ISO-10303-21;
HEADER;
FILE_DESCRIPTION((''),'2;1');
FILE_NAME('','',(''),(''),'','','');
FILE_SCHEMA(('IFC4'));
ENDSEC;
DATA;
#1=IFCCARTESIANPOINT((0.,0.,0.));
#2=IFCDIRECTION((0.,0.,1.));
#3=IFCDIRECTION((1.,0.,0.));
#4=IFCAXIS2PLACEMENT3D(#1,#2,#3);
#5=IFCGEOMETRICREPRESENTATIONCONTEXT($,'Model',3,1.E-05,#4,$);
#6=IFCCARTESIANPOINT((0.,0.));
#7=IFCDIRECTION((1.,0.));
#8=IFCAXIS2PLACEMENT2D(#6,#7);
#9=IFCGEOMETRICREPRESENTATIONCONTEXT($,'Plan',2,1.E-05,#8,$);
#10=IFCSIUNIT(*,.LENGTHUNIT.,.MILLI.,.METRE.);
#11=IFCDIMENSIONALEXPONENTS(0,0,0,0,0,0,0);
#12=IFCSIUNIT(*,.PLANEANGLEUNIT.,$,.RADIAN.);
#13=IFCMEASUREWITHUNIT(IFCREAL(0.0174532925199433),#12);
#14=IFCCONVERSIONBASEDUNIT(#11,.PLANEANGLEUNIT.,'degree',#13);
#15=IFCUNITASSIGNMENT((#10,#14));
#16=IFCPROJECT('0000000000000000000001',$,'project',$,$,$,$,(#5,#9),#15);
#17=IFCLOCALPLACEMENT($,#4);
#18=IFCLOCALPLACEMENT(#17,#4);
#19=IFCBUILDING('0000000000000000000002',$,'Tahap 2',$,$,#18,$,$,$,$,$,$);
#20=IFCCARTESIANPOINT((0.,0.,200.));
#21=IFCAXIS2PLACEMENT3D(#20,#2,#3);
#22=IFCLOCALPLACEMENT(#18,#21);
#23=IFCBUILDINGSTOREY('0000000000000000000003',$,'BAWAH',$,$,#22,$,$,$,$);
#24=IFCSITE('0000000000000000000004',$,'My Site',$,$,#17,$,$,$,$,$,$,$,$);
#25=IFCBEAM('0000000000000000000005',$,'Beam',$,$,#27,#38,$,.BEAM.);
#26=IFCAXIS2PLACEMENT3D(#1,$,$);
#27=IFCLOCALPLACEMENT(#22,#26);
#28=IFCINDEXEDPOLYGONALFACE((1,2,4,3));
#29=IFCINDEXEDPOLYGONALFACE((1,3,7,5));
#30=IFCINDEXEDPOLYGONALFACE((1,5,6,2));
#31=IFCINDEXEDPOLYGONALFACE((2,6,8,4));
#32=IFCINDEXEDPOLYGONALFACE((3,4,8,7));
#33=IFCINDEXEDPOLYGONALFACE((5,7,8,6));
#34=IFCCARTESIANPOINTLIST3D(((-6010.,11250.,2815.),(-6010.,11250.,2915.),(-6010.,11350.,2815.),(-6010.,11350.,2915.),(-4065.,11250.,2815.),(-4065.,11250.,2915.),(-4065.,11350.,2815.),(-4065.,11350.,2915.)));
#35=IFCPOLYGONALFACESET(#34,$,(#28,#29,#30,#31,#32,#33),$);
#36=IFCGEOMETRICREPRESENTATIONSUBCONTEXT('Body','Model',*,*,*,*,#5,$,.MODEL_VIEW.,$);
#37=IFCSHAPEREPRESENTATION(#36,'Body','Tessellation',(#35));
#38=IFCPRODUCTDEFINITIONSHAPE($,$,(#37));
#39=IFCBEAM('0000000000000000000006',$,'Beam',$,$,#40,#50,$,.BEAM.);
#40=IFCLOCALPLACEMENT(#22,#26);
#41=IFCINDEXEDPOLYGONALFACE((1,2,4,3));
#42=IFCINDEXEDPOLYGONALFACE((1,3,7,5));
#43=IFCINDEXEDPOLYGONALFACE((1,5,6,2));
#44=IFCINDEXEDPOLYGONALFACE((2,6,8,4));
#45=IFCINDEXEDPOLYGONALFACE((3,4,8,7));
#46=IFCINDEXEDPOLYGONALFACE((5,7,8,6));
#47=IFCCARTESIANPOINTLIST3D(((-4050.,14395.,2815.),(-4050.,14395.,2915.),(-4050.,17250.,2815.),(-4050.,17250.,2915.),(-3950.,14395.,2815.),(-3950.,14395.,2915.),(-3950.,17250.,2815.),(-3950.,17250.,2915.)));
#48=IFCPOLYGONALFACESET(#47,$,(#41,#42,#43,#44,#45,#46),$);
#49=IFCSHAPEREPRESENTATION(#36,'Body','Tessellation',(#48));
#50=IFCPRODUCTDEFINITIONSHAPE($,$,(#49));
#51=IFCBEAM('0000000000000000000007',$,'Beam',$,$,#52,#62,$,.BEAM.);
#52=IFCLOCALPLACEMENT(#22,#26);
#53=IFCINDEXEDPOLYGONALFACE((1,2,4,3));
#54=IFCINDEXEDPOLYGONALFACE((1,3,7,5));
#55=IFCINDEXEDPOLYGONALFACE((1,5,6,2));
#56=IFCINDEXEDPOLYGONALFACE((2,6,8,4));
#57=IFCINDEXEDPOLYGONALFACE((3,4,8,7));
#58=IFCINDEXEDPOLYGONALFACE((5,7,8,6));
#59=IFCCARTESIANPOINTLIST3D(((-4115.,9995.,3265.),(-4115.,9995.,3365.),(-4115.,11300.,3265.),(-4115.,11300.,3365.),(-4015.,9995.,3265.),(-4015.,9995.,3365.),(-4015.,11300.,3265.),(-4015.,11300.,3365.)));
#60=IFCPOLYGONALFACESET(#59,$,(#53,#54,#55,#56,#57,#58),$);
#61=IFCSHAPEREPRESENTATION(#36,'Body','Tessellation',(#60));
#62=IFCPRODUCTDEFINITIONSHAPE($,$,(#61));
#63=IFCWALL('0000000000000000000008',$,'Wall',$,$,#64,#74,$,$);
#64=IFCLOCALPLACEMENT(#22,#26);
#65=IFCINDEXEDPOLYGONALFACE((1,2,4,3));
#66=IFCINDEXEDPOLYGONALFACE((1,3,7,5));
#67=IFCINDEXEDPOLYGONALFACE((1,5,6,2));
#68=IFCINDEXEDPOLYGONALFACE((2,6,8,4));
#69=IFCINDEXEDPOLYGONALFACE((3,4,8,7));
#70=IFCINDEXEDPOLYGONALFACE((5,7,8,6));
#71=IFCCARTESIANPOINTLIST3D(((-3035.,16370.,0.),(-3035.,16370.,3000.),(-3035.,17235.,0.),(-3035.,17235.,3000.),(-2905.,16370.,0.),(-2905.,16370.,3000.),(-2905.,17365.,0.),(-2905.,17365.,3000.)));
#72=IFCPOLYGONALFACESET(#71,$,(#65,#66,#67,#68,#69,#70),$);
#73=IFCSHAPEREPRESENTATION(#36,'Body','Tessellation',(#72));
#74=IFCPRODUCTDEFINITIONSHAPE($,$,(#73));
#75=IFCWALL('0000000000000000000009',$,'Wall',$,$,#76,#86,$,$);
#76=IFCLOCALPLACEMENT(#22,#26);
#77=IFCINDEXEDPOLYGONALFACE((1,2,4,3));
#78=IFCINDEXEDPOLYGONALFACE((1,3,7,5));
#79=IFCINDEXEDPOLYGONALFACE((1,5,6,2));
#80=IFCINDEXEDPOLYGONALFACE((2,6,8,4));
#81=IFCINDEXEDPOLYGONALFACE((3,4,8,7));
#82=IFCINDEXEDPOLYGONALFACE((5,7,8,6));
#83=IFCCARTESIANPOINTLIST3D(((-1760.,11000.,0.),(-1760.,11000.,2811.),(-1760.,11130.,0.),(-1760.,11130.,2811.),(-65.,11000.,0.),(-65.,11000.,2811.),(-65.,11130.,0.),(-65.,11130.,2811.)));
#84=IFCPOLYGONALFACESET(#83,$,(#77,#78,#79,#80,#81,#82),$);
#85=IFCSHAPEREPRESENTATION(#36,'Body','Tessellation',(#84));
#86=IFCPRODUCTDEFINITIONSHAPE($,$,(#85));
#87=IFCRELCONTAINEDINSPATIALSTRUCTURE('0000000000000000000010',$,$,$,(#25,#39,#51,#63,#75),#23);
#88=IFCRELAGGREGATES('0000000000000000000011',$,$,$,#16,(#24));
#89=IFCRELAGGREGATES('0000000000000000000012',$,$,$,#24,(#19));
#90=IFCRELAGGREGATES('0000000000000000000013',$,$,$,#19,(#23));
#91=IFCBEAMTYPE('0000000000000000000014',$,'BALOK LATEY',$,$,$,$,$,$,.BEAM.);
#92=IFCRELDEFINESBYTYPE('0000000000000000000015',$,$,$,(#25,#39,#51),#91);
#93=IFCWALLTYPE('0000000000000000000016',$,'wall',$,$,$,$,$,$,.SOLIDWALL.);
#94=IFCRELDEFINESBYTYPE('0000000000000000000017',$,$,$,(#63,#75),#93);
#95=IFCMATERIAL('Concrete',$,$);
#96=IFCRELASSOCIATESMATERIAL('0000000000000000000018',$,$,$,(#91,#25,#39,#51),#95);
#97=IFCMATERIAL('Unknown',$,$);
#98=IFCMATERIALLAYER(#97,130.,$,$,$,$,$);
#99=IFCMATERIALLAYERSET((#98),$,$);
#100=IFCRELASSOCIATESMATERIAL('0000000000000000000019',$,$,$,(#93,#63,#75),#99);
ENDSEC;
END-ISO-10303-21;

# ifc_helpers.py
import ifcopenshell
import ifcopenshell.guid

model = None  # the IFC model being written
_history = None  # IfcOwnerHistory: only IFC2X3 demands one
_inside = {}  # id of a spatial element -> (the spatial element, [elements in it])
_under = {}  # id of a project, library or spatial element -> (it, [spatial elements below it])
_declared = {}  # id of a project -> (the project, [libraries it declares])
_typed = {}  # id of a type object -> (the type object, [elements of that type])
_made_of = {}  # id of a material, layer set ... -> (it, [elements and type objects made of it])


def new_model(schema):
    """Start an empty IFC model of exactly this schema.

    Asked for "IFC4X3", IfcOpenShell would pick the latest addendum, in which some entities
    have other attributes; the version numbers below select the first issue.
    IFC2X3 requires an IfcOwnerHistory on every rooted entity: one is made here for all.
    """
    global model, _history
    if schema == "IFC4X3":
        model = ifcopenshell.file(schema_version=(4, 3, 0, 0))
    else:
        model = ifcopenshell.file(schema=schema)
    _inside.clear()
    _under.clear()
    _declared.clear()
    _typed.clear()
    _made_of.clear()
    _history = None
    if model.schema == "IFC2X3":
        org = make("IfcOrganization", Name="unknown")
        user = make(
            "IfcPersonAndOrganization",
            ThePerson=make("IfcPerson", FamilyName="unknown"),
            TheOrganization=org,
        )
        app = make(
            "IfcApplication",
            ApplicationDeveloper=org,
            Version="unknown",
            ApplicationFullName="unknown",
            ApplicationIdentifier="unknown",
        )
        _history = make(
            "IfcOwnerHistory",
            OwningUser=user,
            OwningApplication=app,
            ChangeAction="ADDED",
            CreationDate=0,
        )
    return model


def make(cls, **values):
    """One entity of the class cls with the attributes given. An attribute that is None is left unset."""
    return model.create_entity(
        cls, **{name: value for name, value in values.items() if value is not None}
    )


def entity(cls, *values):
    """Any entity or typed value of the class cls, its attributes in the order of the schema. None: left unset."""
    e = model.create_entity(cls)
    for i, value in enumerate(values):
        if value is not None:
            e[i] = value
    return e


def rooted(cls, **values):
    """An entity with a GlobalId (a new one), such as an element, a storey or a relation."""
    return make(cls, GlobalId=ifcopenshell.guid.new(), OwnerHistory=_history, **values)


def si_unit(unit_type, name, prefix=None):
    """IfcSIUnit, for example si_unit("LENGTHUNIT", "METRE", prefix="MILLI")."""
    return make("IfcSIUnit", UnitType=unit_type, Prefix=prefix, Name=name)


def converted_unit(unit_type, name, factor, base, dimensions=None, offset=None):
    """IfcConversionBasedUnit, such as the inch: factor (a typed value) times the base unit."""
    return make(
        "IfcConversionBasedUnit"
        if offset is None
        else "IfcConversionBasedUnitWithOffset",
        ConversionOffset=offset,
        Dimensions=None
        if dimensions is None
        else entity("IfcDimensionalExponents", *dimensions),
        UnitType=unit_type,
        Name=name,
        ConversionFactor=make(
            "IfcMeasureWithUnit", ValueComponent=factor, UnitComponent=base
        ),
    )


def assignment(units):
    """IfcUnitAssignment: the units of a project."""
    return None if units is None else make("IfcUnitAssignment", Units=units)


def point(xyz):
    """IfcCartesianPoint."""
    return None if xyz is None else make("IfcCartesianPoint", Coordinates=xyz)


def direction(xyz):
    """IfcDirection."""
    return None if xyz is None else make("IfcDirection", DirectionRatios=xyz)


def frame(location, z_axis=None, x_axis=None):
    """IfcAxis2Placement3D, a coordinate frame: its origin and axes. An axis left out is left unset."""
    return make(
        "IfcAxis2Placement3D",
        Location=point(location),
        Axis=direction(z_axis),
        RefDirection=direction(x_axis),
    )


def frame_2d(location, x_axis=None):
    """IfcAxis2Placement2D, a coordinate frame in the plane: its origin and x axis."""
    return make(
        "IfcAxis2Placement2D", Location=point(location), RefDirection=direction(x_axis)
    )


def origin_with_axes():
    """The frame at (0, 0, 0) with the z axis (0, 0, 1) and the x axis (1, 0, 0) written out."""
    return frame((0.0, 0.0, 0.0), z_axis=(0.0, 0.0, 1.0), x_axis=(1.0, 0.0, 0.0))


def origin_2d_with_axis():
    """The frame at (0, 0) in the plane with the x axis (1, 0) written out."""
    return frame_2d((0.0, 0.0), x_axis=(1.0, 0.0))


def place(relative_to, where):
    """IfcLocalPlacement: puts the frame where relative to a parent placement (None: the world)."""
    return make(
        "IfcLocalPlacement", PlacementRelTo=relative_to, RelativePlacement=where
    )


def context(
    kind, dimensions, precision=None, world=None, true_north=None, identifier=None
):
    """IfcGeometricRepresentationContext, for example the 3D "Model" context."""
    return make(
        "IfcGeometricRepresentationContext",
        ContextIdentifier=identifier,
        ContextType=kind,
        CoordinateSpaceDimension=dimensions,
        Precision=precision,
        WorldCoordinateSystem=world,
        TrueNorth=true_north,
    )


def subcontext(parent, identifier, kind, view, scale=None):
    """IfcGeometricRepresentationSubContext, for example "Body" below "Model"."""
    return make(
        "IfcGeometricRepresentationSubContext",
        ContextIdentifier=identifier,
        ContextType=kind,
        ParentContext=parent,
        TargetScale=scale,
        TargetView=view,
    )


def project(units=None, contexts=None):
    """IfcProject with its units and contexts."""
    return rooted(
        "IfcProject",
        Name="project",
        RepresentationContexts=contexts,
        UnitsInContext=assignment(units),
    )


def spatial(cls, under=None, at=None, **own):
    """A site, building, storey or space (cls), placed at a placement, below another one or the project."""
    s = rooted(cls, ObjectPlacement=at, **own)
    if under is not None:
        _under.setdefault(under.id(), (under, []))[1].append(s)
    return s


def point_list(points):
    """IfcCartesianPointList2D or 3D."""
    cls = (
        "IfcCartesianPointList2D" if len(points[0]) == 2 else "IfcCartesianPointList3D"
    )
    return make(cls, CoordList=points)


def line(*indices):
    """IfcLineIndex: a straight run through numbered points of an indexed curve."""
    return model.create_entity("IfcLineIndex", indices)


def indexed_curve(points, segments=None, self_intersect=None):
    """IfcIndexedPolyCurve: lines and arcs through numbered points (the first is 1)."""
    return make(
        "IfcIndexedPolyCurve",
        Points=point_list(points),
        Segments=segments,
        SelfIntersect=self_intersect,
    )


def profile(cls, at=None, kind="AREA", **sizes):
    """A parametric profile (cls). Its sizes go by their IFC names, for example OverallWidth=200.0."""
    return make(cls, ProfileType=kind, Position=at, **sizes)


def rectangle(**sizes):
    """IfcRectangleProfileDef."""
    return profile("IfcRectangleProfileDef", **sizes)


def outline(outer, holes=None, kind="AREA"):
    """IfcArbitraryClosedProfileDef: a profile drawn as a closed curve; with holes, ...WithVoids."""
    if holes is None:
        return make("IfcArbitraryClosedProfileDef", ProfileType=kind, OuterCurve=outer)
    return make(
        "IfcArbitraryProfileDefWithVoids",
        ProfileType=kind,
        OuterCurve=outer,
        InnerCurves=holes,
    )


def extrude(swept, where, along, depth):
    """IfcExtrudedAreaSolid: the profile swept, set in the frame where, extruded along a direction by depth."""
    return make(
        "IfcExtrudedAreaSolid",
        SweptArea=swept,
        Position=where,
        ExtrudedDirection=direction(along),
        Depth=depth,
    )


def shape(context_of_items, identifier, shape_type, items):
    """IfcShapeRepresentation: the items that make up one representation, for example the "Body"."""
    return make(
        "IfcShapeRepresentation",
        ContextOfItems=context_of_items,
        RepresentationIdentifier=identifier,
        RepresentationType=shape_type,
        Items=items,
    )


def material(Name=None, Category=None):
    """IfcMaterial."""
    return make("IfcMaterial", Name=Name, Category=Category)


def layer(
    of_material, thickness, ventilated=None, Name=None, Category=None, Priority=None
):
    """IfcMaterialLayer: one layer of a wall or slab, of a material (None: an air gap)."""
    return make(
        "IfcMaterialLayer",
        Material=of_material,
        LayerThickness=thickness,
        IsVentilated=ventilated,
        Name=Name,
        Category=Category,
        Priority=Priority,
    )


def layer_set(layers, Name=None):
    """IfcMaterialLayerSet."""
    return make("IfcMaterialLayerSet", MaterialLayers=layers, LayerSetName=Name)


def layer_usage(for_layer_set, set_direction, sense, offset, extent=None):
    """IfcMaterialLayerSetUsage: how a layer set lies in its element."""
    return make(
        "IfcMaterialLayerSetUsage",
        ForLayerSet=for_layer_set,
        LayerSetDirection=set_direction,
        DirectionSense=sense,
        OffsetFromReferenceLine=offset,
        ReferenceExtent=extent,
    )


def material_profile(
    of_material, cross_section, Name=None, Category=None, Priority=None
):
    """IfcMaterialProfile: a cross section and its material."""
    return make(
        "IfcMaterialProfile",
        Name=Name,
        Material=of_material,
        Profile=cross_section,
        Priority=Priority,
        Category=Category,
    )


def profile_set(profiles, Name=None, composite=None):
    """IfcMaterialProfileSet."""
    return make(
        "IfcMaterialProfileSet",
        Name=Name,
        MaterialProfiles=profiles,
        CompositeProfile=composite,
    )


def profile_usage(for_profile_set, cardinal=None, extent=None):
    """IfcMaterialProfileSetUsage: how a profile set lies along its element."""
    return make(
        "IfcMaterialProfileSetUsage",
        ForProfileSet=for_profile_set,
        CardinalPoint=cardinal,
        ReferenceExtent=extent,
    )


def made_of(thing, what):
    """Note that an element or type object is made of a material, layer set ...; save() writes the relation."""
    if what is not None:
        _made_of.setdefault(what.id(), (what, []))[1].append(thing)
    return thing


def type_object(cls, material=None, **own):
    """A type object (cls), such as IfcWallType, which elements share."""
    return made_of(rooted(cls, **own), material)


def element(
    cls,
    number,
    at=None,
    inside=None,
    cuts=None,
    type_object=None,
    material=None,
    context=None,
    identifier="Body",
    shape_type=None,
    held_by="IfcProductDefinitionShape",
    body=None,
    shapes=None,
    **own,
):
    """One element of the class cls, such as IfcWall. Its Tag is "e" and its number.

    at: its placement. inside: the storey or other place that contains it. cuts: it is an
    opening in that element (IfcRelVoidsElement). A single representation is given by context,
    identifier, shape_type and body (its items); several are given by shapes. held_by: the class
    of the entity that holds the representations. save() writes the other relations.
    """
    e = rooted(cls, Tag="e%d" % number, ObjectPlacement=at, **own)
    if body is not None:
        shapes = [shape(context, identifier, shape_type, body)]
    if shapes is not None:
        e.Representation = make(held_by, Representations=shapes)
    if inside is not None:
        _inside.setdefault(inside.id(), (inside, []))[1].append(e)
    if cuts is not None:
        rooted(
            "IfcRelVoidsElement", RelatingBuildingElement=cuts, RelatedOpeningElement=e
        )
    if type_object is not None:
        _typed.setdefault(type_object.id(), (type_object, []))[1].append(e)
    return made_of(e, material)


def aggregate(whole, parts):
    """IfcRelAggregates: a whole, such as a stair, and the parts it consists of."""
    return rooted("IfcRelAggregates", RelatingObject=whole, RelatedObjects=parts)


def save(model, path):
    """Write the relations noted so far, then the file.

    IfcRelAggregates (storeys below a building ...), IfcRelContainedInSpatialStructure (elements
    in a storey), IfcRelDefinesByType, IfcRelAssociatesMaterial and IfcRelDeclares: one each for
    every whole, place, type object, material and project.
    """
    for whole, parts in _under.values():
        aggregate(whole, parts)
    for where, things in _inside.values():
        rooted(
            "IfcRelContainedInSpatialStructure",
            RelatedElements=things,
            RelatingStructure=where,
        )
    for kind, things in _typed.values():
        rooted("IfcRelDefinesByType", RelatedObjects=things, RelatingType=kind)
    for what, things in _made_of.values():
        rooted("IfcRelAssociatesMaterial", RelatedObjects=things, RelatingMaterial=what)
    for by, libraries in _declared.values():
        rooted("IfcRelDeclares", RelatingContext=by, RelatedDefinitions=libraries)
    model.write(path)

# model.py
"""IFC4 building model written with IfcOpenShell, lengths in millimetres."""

from ifc_helpers import new_model, entity, si_unit, converted_unit, frame, origin_with_axes, origin_2d_with_axis, place, context, subcontext, project, spatial, line, indexed_curve, rectangle, outline, extrude, material, layer, layer_set, layer_usage, material_profile, profile_set, profile_usage, type_object, element, save


model = new_model("IFC4")

# Units and contexts
model_context = context("Model", 3, precision=1e-05, world=origin_with_axes())
plan_context = context("Plan", 2, precision=1e-05, world=origin_2d_with_axis())
body_context = subcontext(model_context, "Body", "Model", "MODEL_VIEW")
ifc_project = project(units=[si_unit("LENGTHUNIT", "METRE", prefix="MILLI"), converted_unit("PLANEANGLEUNIT", "degree", entity("IfcReal", 0.0174532925199433), si_unit("PLANEANGLEUNIT", "RADIAN"), dimensions=[0, 0, 0, 0, 0, 0, 0])], contexts=[model_context, plan_context])

# Site, building, storey
site_placement = place(None, origin_with_axes())
site = spatial("IfcSite", under=ifc_project, at=site_placement, Name="My Site")
building_placement = place(site_placement, origin_with_axes())
building = spatial("IfcBuilding", under=site, at=building_placement, Name="Tahap 2")
storey_placement = place(building_placement, frame((0.0, 0.0, 200.0), z_axis=(0.0, 0.0, 1.0), x_axis=(1.0, 0.0, 0.0)))
storey = spatial("IfcBuildingStorey", under=building, at=storey_placement, Name="BAWAH")

# Shared definitions
ifc_material_1 = material(Name="Concrete")

# Beams
ifc_material_profile_1 = material_profile(ifc_material_1, rectangle(XDim=100.0, YDim=100.0))
ifc_profile_set_1 = profile_set([ifc_material_profile_1])
ifc_profile_usage_1 = profile_usage(ifc_profile_set_1, cardinal=2)
beam_type_1 = type_object("IfcBeamType", Name="BALOK LATEY", PredefinedType="BEAM", material=ifc_profile_set_1)
beam_1_placement = place(storey_placement, frame((-6010.0, 11300.0, 2815.0), z_axis=(1.0, 0.0, 0.0), x_axis=(0.0, 1.0, 0.0)))
element("IfcBeam", 1, at=beam_1_placement, inside=storey, type_object=beam_type_1, material=ifc_profile_usage_1, Name="Beam", PredefinedType="BEAM", context=body_context, shape_type="SweptSolid", body=[
    extrude(rectangle(XDim=100.0, YDim=100.0), frame((0.0, 50.0, 0.0), z_axis=(0.0, 0.0, 1.0), x_axis=(1.0, 0.0, 0.0)), (0.0, 0.0, 1.0), 1945.0),
])
ifc_profile_usage_2 = profile_usage(ifc_profile_set_1, cardinal=2)
beam_2_placement = place(storey_placement, frame((-4000.0, 14395.0, 2815.0), z_axis=(0.0, 1.0, 0.0), x_axis=(-1.0, 0.0, 0.0)))
element("IfcBeam", 2, at=beam_2_placement, inside=storey, type_object=beam_type_1, material=ifc_profile_usage_2, Name="Beam", PredefinedType="BEAM", context=body_context, shape_type="SweptSolid", body=[
    extrude(rectangle(XDim=100.0, YDim=100.0), frame((0.0, 50.0, 0.0), z_axis=(0.0, 0.0, 1.0), x_axis=(1.0, 0.0, 0.0)), (0.0, 0.0, 1.0), 2855.0),
])
ifc_profile_usage_3 = profile_usage(ifc_profile_set_1, cardinal=2)
beam_3_placement = place(storey_placement, frame((-4065.0, 11300.0, 3265.0), z_axis=(0.0, -1.0, 0.0), x_axis=(1.0, 0.0, 0.0)))
element("IfcBeam", 3, at=beam_3_placement, inside=storey, type_object=beam_type_1, material=ifc_profile_usage_3, Name="Beam", PredefinedType="BEAM", context=body_context, shape_type="SweptSolid", body=[
    extrude(rectangle(XDim=100.0, YDim=100.0), frame((0.0, 50.0, 0.0), z_axis=(0.0, 0.0, 1.0), x_axis=(1.0, 0.0, 0.0)), (0.0, 0.0, 1.0), 1305.0),
])

# Walls
ifc_material_2 = material(Name="Unknown")
ifc_layer = layer(ifc_material_2, 130.0)
ifc_layer_set = layer_set([ifc_layer])
ifc_layer_usage_1 = layer_usage(ifc_layer_set, "AXIS2", "POSITIVE", 0.0)
wall_type = type_object("IfcWallType", Name="wall", PredefinedType="SOLIDWALL", material=ifc_layer_set)
wall_1_placement = place(storey_placement, frame((-2905.0, 16370.0, 0.0), z_axis=(0.0, 0.0, 1.0), x_axis=(0.0, 1.0, 0.0)))
element("IfcWall", 4, at=wall_1_placement, inside=storey, type_object=wall_type, material=ifc_layer_usage_1, Name="Wall", context=body_context, shape_type="SweptSolid", body=[
    extrude(outline(indexed_curve([(0.0, 0.0), (0.0, 130.0), (865.0, 130.0), (995.0, 0.0)], segments=[line(1, 2, 3, 4, 1)])), origin_with_axes(), (0.0, 0.0, 1.0), 3000.0),
])
ifc_layer_usage_2 = layer_usage(ifc_layer_set, "AXIS2", "NEGATIVE", 0.0)
wall_2_placement = place(storey_placement, frame((-1760.0, 11130.0, 0.0), z_axis=(0.0, 0.0, 1.0), x_axis=(1.0, 0.0, 0.0)))
element("IfcWall", 5, at=wall_2_placement, inside=storey, type_object=wall_type, material=ifc_layer_usage_2, Name="Wall", context=body_context, shape_type="SweptSolid", body=[
    extrude(outline(indexed_curve([(0.0, -130.0), (0.0, 0.0), (1695.0, 0.0), (1695.0, -130.0)], segments=[line(1, 2, 3, 4, 1)])), origin_with_axes(), (0.0, 0.0, 1.0), 2811.0),
])

save(model, "model.ifc")
